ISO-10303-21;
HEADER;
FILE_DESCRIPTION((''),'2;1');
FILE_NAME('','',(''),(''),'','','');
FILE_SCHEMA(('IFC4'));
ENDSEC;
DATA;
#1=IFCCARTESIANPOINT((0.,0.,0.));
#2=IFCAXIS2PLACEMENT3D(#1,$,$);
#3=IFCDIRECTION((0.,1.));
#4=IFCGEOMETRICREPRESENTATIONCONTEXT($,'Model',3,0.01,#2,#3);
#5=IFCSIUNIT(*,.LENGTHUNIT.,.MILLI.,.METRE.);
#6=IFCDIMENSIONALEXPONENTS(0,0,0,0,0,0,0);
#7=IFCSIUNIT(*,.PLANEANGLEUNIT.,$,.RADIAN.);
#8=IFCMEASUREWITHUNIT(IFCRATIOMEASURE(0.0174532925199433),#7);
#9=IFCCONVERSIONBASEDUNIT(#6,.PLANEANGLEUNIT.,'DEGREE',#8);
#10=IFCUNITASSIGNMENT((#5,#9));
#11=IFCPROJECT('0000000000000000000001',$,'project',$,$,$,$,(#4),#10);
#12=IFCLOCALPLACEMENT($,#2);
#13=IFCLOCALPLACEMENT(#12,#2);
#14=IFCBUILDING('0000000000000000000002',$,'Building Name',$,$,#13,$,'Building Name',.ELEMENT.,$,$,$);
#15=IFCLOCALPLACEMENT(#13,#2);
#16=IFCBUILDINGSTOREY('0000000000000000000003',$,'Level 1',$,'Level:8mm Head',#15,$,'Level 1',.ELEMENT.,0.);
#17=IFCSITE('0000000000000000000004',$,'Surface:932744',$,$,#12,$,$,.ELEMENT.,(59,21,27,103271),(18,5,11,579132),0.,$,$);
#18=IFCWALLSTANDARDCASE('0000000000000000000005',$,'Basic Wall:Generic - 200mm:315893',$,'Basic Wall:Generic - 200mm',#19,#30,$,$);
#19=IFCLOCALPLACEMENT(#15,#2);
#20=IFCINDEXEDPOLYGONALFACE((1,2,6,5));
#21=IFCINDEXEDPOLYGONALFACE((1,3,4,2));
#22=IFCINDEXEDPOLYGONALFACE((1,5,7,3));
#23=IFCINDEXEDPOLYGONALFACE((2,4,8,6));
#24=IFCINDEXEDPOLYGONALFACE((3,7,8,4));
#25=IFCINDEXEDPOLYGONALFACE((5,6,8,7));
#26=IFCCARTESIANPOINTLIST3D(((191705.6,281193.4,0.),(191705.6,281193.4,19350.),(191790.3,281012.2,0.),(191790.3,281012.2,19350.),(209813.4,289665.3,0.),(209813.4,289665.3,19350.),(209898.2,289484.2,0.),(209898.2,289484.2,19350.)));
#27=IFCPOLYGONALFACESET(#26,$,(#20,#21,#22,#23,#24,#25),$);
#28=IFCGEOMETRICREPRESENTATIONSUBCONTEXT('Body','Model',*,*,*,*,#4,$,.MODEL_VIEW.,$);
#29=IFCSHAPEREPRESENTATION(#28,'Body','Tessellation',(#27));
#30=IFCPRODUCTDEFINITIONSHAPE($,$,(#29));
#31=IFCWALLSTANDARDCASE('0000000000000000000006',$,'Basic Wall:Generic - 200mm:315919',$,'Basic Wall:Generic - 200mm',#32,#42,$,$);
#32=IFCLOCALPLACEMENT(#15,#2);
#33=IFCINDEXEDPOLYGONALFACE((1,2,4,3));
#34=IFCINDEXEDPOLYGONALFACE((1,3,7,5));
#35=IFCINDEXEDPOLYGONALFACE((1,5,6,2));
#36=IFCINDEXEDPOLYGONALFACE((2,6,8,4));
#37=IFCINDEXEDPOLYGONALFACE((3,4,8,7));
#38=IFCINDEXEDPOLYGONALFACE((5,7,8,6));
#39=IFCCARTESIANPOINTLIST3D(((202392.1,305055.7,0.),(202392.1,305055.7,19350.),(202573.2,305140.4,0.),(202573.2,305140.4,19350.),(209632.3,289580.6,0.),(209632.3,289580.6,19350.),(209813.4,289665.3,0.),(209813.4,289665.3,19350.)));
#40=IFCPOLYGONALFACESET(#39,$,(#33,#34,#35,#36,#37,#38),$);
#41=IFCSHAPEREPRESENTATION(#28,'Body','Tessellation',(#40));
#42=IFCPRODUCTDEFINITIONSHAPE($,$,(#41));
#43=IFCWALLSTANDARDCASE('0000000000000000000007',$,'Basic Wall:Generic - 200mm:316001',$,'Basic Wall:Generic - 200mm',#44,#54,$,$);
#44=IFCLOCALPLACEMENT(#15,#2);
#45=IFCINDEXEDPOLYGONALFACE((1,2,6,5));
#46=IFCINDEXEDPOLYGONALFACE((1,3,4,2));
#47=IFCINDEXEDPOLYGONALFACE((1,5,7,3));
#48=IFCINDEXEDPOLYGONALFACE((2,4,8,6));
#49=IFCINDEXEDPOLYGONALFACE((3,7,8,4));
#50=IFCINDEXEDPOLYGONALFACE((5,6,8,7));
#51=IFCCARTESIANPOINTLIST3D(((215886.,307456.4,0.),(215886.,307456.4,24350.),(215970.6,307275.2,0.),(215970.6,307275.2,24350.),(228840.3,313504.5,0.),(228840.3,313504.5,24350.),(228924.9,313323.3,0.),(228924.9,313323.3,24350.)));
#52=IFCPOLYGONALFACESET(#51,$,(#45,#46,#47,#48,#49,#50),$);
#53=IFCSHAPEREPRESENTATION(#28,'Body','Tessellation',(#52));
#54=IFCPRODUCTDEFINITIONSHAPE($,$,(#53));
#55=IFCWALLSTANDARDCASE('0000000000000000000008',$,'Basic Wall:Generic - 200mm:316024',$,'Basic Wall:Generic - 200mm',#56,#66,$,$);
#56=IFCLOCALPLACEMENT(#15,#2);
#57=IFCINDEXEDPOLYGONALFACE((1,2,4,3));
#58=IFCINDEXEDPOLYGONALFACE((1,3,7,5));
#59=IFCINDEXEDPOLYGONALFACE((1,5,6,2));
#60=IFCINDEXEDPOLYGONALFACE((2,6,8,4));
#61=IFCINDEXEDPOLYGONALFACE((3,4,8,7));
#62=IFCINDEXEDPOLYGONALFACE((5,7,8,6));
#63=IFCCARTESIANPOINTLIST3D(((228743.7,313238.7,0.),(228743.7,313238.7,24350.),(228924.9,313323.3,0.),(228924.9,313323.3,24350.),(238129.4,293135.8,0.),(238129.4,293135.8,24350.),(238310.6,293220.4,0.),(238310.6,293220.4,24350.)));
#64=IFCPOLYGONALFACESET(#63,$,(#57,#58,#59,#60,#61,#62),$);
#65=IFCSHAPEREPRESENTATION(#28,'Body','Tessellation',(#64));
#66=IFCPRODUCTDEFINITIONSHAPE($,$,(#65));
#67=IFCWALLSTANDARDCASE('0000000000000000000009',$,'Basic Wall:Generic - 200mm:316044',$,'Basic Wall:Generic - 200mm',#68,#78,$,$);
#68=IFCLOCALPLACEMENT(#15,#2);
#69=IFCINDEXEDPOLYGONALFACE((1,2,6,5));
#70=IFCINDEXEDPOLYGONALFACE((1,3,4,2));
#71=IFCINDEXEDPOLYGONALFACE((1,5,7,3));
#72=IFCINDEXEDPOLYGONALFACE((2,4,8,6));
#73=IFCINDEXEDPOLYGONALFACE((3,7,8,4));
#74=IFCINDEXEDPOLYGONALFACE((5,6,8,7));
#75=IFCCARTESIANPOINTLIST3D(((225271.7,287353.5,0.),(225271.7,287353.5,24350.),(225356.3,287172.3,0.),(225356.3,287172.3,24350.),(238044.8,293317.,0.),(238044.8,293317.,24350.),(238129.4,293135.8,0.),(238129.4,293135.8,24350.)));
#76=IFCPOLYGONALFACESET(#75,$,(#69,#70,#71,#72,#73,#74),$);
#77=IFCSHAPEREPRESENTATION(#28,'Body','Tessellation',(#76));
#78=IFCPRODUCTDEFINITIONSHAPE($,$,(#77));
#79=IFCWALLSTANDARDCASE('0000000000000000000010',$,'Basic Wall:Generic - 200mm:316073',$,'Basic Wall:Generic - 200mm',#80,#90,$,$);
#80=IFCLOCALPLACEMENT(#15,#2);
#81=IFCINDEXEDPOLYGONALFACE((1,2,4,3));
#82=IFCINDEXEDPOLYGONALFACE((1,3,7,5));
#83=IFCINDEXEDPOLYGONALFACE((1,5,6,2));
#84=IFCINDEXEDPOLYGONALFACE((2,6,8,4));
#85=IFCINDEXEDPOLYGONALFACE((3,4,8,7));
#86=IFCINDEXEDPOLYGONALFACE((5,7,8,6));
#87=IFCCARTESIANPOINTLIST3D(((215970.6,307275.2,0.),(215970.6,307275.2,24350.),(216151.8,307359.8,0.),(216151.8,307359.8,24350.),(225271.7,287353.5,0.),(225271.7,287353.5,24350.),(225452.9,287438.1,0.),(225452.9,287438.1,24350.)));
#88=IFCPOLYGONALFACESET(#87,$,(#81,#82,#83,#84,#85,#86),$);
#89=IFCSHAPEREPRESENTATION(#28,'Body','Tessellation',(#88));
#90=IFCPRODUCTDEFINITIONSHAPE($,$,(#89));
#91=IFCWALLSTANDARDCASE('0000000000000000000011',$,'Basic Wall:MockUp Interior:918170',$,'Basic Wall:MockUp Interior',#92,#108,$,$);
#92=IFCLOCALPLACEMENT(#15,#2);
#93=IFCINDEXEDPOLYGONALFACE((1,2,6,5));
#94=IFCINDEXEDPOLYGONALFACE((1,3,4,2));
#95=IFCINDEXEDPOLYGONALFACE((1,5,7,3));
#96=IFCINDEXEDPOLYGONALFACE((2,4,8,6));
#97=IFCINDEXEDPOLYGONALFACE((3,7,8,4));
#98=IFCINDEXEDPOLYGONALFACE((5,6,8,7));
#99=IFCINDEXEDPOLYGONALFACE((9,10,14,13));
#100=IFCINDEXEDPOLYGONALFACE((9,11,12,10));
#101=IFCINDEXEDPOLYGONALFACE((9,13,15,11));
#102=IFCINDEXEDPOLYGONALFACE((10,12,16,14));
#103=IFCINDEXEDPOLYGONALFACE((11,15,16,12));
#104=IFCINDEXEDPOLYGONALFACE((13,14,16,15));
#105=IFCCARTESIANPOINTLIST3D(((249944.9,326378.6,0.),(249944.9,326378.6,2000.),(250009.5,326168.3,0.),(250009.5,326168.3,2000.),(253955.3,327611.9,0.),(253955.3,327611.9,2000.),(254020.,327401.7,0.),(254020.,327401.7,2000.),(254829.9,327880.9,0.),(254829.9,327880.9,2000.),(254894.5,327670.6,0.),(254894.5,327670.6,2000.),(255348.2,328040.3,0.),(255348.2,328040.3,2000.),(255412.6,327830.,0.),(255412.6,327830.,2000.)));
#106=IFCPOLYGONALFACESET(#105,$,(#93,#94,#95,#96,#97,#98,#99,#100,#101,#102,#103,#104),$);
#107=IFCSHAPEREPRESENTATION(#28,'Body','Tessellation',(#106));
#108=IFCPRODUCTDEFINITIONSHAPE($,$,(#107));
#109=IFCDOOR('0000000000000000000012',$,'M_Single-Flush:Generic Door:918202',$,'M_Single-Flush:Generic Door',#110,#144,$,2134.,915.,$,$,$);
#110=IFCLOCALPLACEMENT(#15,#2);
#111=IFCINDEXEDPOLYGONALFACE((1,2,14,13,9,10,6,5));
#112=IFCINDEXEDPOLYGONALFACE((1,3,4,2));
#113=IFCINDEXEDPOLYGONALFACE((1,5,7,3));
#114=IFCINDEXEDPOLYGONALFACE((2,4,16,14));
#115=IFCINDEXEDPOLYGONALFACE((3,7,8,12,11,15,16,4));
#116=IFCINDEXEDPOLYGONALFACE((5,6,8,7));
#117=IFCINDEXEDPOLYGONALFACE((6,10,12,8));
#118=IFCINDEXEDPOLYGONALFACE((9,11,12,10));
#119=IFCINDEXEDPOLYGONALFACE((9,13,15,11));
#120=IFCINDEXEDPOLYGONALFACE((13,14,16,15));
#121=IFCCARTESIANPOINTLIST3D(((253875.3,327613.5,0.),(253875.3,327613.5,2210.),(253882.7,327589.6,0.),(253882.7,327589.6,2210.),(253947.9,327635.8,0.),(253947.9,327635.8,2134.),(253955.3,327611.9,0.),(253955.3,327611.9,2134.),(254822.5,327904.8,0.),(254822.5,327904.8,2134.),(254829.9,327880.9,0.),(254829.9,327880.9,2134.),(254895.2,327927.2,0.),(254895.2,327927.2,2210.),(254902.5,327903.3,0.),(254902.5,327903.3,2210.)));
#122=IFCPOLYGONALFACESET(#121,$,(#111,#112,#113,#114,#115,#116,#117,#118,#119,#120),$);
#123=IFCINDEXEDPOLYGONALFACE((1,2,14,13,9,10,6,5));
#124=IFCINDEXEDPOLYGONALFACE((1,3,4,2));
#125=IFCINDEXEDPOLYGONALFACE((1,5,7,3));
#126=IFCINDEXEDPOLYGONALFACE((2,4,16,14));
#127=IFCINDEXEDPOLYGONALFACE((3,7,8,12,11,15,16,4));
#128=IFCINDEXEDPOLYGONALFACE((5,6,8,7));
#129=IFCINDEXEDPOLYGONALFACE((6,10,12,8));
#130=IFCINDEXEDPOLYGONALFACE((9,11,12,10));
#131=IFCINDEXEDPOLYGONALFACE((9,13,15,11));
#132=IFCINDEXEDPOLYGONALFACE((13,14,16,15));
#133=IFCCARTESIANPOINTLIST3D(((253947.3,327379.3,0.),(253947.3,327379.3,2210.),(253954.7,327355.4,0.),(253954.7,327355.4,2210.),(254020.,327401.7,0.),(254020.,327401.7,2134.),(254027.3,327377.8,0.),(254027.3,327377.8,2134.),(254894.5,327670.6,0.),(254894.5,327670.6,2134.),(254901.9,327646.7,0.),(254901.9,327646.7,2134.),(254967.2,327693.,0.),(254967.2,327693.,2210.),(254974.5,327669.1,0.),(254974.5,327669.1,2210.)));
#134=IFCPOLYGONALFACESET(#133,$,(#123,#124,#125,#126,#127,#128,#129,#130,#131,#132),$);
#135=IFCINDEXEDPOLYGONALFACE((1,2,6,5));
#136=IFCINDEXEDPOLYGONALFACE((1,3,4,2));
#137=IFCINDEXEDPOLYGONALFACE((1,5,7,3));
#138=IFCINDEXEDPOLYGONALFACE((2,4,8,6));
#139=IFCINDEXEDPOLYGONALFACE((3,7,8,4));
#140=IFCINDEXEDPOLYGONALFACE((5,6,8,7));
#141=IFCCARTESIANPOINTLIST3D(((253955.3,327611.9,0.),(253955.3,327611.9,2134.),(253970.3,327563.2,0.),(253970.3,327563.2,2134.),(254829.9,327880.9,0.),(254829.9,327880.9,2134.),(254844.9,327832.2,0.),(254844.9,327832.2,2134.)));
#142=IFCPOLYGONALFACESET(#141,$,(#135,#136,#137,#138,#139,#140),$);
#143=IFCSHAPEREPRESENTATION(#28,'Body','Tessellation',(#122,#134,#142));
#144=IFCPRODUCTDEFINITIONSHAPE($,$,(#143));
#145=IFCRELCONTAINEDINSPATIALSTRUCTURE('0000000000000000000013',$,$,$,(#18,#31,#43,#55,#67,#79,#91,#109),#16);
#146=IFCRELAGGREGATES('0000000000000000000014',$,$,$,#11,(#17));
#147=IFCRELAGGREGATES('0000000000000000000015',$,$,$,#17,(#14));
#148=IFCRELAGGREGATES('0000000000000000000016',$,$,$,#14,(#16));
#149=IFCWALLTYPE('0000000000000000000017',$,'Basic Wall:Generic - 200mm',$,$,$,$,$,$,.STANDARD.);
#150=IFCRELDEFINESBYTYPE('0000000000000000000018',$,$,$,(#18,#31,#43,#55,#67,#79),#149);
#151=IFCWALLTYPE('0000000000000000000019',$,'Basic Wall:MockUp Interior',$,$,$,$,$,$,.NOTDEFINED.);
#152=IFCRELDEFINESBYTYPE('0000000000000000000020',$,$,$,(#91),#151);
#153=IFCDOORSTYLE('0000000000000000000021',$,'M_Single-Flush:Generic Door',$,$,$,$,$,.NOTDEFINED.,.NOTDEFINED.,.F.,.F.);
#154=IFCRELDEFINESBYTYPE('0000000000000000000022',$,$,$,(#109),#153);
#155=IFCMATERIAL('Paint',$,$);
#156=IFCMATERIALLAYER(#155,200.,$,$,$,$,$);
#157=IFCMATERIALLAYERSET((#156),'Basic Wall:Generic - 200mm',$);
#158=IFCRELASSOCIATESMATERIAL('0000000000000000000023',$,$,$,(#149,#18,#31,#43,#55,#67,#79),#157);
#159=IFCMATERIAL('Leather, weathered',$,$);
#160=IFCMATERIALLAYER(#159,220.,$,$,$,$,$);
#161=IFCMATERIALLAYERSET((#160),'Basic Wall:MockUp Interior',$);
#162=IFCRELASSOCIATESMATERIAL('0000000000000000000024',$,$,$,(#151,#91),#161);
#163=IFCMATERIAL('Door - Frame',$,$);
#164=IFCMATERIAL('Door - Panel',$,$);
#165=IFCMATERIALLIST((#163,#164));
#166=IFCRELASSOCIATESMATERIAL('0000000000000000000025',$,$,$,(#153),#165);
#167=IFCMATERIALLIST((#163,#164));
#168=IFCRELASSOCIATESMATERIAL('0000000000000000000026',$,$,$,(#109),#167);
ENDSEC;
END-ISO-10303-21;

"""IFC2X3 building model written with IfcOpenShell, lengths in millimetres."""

from ifc_helpers import new_model, entity, si_unit, converted_unit, direction, frame, frame_2d, origin, place, context, subcontext, project, spatial, polyline, rectangle, outline, extrude, clip, bounded_halfspace, source, transform, mapped, material, material_list, layer, layer_set, layer_usage, type_object, type_shapes, element, fill, save


model = new_model("IFC2X3")

# Units and contexts
model_context = context("Model", 3, precision=0.01, world=origin(), true_north=direction((0.0, 1.0)))
body_context = subcontext(model_context, "Body", "Model", "MODEL_VIEW")
ifc_project = project(units=[si_unit("LENGTHUNIT", "METRE", prefix="MILLI"), converted_unit("PLANEANGLEUNIT", "DEGREE", entity("IfcRatioMeasure", 0.0174532925199433), si_unit("PLANEANGLEUNIT", "RADIAN"), dimensions=[0, 0, 0, 0, 0, 0, 0])], contexts=[model_context])

# Site, building, storey
site_placement = place(None, origin())
site = spatial("IfcSite", under=ifc_project, at=site_placement, Name="Surface:932744", CompositionType="ELEMENT", RefLatitude=(59, 21, 27, 103271), RefLongitude=(18, 5, 11, 579132), RefElevation=0.0)
building_placement = place(site_placement, origin())
building = spatial("IfcBuilding", under=site, at=building_placement, Name="Building Name", LongName="Building Name", CompositionType="ELEMENT")
storey_placement = place(building_placement, origin())
storey = spatial("IfcBuildingStorey", under=building, at=storey_placement, Name="Level 1", ObjectType="Level:8mm Head", LongName="Level 1", CompositionType="ELEMENT", Elevation=0.0)

# Shared definitions
ifc_material_1 = material(Name="Paint")
ifc_layer_1 = layer(ifc_material_1, 200.0)
ifc_layer_set_1 = layer_set([ifc_layer_1], Name="Basic Wall:Generic - 200mm")
wall_type_1 = type_object("IfcWallType", Name="Basic Wall:Generic - 200mm", PredefinedType="STANDARD", material=ifc_layer_set_1)

# Walls
ifc_layer_usage_1 = layer_usage(ifc_layer_set_1, "AXIS2", "NEGATIVE", 100.0)
wall_1_placement = place(storey_placement, frame((191748.0, 281102.8, 0.0), z_axis=(0.0, 0.0, 1.0), x_axis=(0.905768, 0.423773, 0.0)))
element("IfcWallStandardCase", 1, at=wall_1_placement, inside=storey, type_object=wall_type_1, material=ifc_layer_usage_1, Name="Basic Wall:Generic - 200mm:315893", ObjectType="Basic Wall:Generic - 200mm", context=body_context, shape_type="Clipping", body=[
    clip(extrude(rectangle(XDim=19991.7, YDim=200.0, at=frame_2d((9995.8, 0.0), x_axis=(-1.0, 0.0))), origin(), (0.0, 0.0, 1.0), 19350.0), bounded_halfspace(frame((0.0, -100.0, 19350.0), z_axis=(0.0, 0.0, -1.0), x_axis=(1.0, 0.0, 0.0)), True, frame((0.0, -100.0, 19350.0), z_axis=(0.0, 0.0, -1.0), x_axis=(1.0, 0.0, 0.0)), polyline([(0.0, 0.0), (0.0, -200.0), (19791.7, -200.0), (19991.7, -200.0), (19991.7, 0.0), (0.0, 0.0)]))),
])
ifc_layer_usage_2 = layer_usage(ifc_layer_set_1, "AXIS2", "NEGATIVE", 100.0)
wall_2_placement = place(storey_placement, frame((209722.8, 289623.0, 0.0), z_axis=(0.0, 0.0, 1.0), x_axis=(-0.423773, 0.905768, 0.0)))
element("IfcWallStandardCase", 2, at=wall_2_placement, inside=storey, type_object=wall_type_1, material=ifc_layer_usage_2, Name="Basic Wall:Generic - 200mm:315919", ObjectType="Basic Wall:Generic - 200mm", context=body_context, shape_type="Clipping", body=[
    clip(extrude(rectangle(XDim=17085.0, YDim=200.0, at=frame_2d((8542.5, 0.0), x_axis=(-1.0, 0.0))), origin(), (0.0, 0.0, 1.0), 19350.0), bounded_halfspace(frame((0.0, -100.0, 19350.0), z_axis=(0.0, 0.0, -1.0), x_axis=(0.0, -1.0, 0.0)), True, frame((0.0, -100.0, 19350.0), z_axis=(0.0, 0.0, -1.0), x_axis=(0.0, -1.0, 0.0)), polyline([(0.0, 0.0), (-200.0, 0.0), (-200.0, -17085.0), (0.0, -17085.0), (0.0, 0.0)]))),
])
ifc_layer_usage_3 = layer_usage(ifc_layer_set_1, "AXIS2", "NEGATIVE", 100.0)
wall_3_placement = place(storey_placement, frame((215928.3, 307365.8, 0.0), z_axis=(0.0, 0.0, 1.0), x_axis=(0.906108, 0.423046, 0.0)))
element("IfcWallStandardCase", 3, at=wall_3_placement, inside=storey, type_object=wall_type_1, material=ifc_layer_usage_3, Name="Basic Wall:Generic - 200mm:316001", ObjectType="Basic Wall:Generic - 200mm", context=body_context, shape_type="Clipping", body=[
    clip(extrude(rectangle(XDim=14296.7, YDim=200.0, at=frame_2d((7148.3, 0.0), x_axis=(-1.0, 0.0))), origin(), (0.0, 0.0, 1.0), 24350.0), bounded_halfspace(frame((0.0, -100.0, 24350.0), z_axis=(0.0, 0.0, -1.0), x_axis=(0.0, -1.0, 0.0)), True, frame((0.0, -100.0, 24350.0), z_axis=(0.0, 0.0, -1.0), x_axis=(0.0, -1.0, 0.0)), polyline([(0.0, 0.0), (-200.0, 0.0), (-200.0, -14296.7), (0.0, -14296.7), (0.0, -14096.7), (0.0, -200.0), (0.0, 0.0)]))),
])
ifc_layer_usage_4 = layer_usage(ifc_layer_set_1, "AXIS2", "NEGATIVE", 100.0)
wall_4_placement = place(storey_placement, frame((228834.3, 313281.0, 0.0), z_axis=(0.0, 0.0, 1.0), x_axis=(0.423046, -0.906108, 0.0)))
element("IfcWallStandardCase", 4, at=wall_4_placement, inside=storey, type_object=wall_type_1, material=ifc_layer_usage_4, Name="Basic Wall:Generic - 200mm:316024", ObjectType="Basic Wall:Generic - 200mm", context=body_context, shape_type="Clipping", body=[
    clip(extrude(rectangle(XDim=22186.0, YDim=200.0, at=frame_2d((11093.0, 0.0), x_axis=(-1.0, 0.0))), origin(), (0.0, 0.0, 1.0), 24350.0), bounded_halfspace(frame((0.0, -100.0, 24350.0), z_axis=(0.0, 0.0, -1.0), x_axis=(1.0, 0.0, 0.0)), True, frame((0.0, -100.0, 24350.0), z_axis=(0.0, 0.0, -1.0), x_axis=(1.0, 0.0, 0.0)), polyline([(0.0, 0.0), (0.0, -200.0), (22186.0, -200.0), (22186.0, 0.0), (0.0, 0.0)]))),
])
ifc_layer_usage_5 = layer_usage(ifc_layer_set_1, "AXIS2", "NEGATIVE", 100.0)
wall_5_placement = place(storey_placement, frame((238087.1, 293226.4, 0.0), z_axis=(0.0, 0.0, 1.0), x_axis=(-0.906108, -0.423046, 0.0)))
element("IfcWallStandardCase", 5, at=wall_5_placement, inside=storey, type_object=wall_type_1, material=ifc_layer_usage_5, Name="Basic Wall:Generic - 200mm:316044", ObjectType="Basic Wall:Generic - 200mm", context=body_context, shape_type="Clipping", body=[
    clip(extrude(rectangle(XDim=14096.7, YDim=200.0, at=frame_2d((7048.3, 0.0), x_axis=(-1.0, 0.0))), origin(), (0.0, 0.0, 1.0), 24350.0), bounded_halfspace(frame((0.0, -100.0, 24350.0), z_axis=(0.0, 0.0, -1.0), x_axis=(0.0, 1.0, 0.0)), True, frame((0.0, -100.0, 24350.0), z_axis=(0.0, 0.0, -1.0), x_axis=(0.0, 1.0, 0.0)), polyline([(0.0, 0.0), (200.0, 0.0), (200.0, 14096.7), (0.0, 14096.7), (0.0, 13896.7), (0.0, 0.0)]))),
])
ifc_layer_usage_6 = layer_usage(ifc_layer_set_1, "AXIS2", "NEGATIVE", 100.0)
wall_6_placement = place(storey_placement, frame((225362.3, 287395.8, 0.0), z_axis=(0.0, 0.0, 1.0), x_axis=(-0.423046, 0.906108, 0.0)))
element("IfcWallStandardCase", 6, at=wall_6_placement, inside=storey, type_object=wall_type_1, material=ifc_layer_usage_6, Name="Basic Wall:Generic - 200mm:316073", ObjectType="Basic Wall:Generic - 200mm", context=body_context, shape_type="Clipping", body=[
    clip(extrude(rectangle(XDim=21986.0, YDim=200.0, at=frame_2d((10993.0, 0.0), x_axis=(-1.0, 0.0))), origin(), (0.0, 0.0, 1.0), 24350.0), bounded_halfspace(frame((0.0, -100.0, 24350.0), z_axis=(0.0, 0.0, -1.0), x_axis=(-1.0, 0.0, 0.0)), True, frame((0.0, -100.0, 24350.0), z_axis=(0.0, 0.0, -1.0), x_axis=(-1.0, 0.0, 0.0)), polyline([(0.0, 0.0), (0.0, 200.0), (-21986.0, 200.0), (-21986.0, 0.0), (0.0, 0.0)]))),
])

# Wall, opening, door
ifc_material_2 = material(Name="Leather, weathered")
ifc_layer_2 = layer(ifc_material_2, 220.0)
ifc_layer_set_2 = layer_set([ifc_layer_2], Name="Basic Wall:MockUp Interior")
ifc_layer_usage_7 = layer_usage(ifc_layer_set_2, "AXIS2", "NEGATIVE", 110.0)
wall_type_2 = type_object("IfcWallType", Name="Basic Wall:MockUp Interior", PredefinedType="NOTDEFINED", material=ifc_layer_set_2)
wall_7_placement = place(building_placement, frame((255380.5, 327935.2, 0.0), z_axis=(0.0, 0.0, 1.0), x_axis=(-0.955818, -0.293958, 0.0)))
wall_7 = element("IfcWallStandardCase", 7, at=wall_7_placement, inside=storey, type_object=wall_type_2, material=ifc_layer_usage_7, Name="Basic Wall:MockUp Interior:918170", ObjectType="Basic Wall:MockUp Interior", context=body_context, shape_type="SweptSolid", body=[
    extrude(outline(polyline([(0.2, 110.0), (0.0, -110.0), (5653.0, -110.0), (5653.0, 110.0), (0.2, 110.0)])), origin(), (0.0, 0.0, 1.0), 2000.0),
])
opening_1_placement = place(wall_7_placement, frame((1457.3, 110.0, 0.0)))
opening_1 = element("IfcOpeningElement", 8, at=opening_1_placement, cuts=wall_7, ObjectType="Opening", context=body_context, shape_type="SweptSolid", body=[
    extrude(rectangle(XDim=915.0, YDim=2134.0, at=frame_2d((1067.0, 457.5), x_axis=(0.0, 1.0))), frame((0.0, 0.0, 0.0), z_axis=(0.0, -1.0, 0.0), x_axis=(0.0, 0.0, 1.0)), (0.0, 0.0, 1.0), 220.0),
])
ifc_material_3 = material(Name="Door - Frame")
ifc_material_4 = material(Name="Door - Panel")
ifc_material_list_1 = material_list([ifc_material_3, ifc_material_4])
ifc_material_list_2 = material_list([ifc_material_3, ifc_material_4])
door_style = type_object("IfcDoorStyle", Name="M_Single-Flush:Generic Door", ConstructionType="NOTDEFINED", OperationType="NOTDEFINED", ParameterTakesPrecedence=False, Sizeable=False, material=ifc_material_list_2)
shared_shape = source(origin(), body_context, "Body", "SweptSolid", [
    extrude(outline(polyline([(-533.5, -1124.0), (533.5, -1124.0), (533.5, 1086.0), (457.5, 1086.0), (457.5, -1048.0), (-457.5, -1048.0), (-457.5, 1086.0), (-533.5, 1086.0), (-533.5, -1124.0)])), frame((457.5, 220.0, 1086.0), z_axis=(0.0, 1.0, 0.0), x_axis=(1.0, 0.0, 0.0)), (0.0, 0.0, 1.0), 25.0),
    extrude(outline(polyline([(-1124.0, -533.5), (1086.0, -533.5), (1086.0, -457.5), (-1048.0, -457.5), (-1048.0, 457.5), (1086.0, 457.5), (1086.0, 533.5), (-1124.0, 533.5), (-1124.0, -533.5)])), frame((457.5, -25.0, 1086.0), z_axis=(0.0, 1.0, 0.0), x_axis=(0.0, 0.0, -1.0)), (0.0, 0.0, 1.0), 25.0),
    extrude(rectangle(XDim=51.0, YDim=915.0, at=frame_2d((0.0, 0.0), x_axis=(1.0, 0.0))), frame((457.5, 194.5, 0.0), z_axis=(0.0, 0.0, 1.0), x_axis=(0.0, 1.0, 0.0)), (0.0, 0.0, 1.0), 2134.0),
])
type_shapes(door_style, [shared_shape])
door_placement = place(opening_1_placement, frame((0.0, 0.0, 0.0), z_axis=(0.0, 0.0, 1.0), x_axis=(-1.0, 0.0, 0.0)))
door = element("IfcDoor", 9, at=door_placement, inside=storey, type_object=door_style, material=ifc_material_list_1, Name="M_Single-Flush:Generic Door:918202", ObjectType="M_Single-Flush:Generic Door", OverallHeight=2134.0, OverallWidth=915.0, context=body_context, shape_type="MappedRepresentation", body=[
    mapped(shared_shape, transform((0.0, 0.0, 0.0), scale=1.0)),
])
fill(opening_1, door)

save(model, "model.ifc")
